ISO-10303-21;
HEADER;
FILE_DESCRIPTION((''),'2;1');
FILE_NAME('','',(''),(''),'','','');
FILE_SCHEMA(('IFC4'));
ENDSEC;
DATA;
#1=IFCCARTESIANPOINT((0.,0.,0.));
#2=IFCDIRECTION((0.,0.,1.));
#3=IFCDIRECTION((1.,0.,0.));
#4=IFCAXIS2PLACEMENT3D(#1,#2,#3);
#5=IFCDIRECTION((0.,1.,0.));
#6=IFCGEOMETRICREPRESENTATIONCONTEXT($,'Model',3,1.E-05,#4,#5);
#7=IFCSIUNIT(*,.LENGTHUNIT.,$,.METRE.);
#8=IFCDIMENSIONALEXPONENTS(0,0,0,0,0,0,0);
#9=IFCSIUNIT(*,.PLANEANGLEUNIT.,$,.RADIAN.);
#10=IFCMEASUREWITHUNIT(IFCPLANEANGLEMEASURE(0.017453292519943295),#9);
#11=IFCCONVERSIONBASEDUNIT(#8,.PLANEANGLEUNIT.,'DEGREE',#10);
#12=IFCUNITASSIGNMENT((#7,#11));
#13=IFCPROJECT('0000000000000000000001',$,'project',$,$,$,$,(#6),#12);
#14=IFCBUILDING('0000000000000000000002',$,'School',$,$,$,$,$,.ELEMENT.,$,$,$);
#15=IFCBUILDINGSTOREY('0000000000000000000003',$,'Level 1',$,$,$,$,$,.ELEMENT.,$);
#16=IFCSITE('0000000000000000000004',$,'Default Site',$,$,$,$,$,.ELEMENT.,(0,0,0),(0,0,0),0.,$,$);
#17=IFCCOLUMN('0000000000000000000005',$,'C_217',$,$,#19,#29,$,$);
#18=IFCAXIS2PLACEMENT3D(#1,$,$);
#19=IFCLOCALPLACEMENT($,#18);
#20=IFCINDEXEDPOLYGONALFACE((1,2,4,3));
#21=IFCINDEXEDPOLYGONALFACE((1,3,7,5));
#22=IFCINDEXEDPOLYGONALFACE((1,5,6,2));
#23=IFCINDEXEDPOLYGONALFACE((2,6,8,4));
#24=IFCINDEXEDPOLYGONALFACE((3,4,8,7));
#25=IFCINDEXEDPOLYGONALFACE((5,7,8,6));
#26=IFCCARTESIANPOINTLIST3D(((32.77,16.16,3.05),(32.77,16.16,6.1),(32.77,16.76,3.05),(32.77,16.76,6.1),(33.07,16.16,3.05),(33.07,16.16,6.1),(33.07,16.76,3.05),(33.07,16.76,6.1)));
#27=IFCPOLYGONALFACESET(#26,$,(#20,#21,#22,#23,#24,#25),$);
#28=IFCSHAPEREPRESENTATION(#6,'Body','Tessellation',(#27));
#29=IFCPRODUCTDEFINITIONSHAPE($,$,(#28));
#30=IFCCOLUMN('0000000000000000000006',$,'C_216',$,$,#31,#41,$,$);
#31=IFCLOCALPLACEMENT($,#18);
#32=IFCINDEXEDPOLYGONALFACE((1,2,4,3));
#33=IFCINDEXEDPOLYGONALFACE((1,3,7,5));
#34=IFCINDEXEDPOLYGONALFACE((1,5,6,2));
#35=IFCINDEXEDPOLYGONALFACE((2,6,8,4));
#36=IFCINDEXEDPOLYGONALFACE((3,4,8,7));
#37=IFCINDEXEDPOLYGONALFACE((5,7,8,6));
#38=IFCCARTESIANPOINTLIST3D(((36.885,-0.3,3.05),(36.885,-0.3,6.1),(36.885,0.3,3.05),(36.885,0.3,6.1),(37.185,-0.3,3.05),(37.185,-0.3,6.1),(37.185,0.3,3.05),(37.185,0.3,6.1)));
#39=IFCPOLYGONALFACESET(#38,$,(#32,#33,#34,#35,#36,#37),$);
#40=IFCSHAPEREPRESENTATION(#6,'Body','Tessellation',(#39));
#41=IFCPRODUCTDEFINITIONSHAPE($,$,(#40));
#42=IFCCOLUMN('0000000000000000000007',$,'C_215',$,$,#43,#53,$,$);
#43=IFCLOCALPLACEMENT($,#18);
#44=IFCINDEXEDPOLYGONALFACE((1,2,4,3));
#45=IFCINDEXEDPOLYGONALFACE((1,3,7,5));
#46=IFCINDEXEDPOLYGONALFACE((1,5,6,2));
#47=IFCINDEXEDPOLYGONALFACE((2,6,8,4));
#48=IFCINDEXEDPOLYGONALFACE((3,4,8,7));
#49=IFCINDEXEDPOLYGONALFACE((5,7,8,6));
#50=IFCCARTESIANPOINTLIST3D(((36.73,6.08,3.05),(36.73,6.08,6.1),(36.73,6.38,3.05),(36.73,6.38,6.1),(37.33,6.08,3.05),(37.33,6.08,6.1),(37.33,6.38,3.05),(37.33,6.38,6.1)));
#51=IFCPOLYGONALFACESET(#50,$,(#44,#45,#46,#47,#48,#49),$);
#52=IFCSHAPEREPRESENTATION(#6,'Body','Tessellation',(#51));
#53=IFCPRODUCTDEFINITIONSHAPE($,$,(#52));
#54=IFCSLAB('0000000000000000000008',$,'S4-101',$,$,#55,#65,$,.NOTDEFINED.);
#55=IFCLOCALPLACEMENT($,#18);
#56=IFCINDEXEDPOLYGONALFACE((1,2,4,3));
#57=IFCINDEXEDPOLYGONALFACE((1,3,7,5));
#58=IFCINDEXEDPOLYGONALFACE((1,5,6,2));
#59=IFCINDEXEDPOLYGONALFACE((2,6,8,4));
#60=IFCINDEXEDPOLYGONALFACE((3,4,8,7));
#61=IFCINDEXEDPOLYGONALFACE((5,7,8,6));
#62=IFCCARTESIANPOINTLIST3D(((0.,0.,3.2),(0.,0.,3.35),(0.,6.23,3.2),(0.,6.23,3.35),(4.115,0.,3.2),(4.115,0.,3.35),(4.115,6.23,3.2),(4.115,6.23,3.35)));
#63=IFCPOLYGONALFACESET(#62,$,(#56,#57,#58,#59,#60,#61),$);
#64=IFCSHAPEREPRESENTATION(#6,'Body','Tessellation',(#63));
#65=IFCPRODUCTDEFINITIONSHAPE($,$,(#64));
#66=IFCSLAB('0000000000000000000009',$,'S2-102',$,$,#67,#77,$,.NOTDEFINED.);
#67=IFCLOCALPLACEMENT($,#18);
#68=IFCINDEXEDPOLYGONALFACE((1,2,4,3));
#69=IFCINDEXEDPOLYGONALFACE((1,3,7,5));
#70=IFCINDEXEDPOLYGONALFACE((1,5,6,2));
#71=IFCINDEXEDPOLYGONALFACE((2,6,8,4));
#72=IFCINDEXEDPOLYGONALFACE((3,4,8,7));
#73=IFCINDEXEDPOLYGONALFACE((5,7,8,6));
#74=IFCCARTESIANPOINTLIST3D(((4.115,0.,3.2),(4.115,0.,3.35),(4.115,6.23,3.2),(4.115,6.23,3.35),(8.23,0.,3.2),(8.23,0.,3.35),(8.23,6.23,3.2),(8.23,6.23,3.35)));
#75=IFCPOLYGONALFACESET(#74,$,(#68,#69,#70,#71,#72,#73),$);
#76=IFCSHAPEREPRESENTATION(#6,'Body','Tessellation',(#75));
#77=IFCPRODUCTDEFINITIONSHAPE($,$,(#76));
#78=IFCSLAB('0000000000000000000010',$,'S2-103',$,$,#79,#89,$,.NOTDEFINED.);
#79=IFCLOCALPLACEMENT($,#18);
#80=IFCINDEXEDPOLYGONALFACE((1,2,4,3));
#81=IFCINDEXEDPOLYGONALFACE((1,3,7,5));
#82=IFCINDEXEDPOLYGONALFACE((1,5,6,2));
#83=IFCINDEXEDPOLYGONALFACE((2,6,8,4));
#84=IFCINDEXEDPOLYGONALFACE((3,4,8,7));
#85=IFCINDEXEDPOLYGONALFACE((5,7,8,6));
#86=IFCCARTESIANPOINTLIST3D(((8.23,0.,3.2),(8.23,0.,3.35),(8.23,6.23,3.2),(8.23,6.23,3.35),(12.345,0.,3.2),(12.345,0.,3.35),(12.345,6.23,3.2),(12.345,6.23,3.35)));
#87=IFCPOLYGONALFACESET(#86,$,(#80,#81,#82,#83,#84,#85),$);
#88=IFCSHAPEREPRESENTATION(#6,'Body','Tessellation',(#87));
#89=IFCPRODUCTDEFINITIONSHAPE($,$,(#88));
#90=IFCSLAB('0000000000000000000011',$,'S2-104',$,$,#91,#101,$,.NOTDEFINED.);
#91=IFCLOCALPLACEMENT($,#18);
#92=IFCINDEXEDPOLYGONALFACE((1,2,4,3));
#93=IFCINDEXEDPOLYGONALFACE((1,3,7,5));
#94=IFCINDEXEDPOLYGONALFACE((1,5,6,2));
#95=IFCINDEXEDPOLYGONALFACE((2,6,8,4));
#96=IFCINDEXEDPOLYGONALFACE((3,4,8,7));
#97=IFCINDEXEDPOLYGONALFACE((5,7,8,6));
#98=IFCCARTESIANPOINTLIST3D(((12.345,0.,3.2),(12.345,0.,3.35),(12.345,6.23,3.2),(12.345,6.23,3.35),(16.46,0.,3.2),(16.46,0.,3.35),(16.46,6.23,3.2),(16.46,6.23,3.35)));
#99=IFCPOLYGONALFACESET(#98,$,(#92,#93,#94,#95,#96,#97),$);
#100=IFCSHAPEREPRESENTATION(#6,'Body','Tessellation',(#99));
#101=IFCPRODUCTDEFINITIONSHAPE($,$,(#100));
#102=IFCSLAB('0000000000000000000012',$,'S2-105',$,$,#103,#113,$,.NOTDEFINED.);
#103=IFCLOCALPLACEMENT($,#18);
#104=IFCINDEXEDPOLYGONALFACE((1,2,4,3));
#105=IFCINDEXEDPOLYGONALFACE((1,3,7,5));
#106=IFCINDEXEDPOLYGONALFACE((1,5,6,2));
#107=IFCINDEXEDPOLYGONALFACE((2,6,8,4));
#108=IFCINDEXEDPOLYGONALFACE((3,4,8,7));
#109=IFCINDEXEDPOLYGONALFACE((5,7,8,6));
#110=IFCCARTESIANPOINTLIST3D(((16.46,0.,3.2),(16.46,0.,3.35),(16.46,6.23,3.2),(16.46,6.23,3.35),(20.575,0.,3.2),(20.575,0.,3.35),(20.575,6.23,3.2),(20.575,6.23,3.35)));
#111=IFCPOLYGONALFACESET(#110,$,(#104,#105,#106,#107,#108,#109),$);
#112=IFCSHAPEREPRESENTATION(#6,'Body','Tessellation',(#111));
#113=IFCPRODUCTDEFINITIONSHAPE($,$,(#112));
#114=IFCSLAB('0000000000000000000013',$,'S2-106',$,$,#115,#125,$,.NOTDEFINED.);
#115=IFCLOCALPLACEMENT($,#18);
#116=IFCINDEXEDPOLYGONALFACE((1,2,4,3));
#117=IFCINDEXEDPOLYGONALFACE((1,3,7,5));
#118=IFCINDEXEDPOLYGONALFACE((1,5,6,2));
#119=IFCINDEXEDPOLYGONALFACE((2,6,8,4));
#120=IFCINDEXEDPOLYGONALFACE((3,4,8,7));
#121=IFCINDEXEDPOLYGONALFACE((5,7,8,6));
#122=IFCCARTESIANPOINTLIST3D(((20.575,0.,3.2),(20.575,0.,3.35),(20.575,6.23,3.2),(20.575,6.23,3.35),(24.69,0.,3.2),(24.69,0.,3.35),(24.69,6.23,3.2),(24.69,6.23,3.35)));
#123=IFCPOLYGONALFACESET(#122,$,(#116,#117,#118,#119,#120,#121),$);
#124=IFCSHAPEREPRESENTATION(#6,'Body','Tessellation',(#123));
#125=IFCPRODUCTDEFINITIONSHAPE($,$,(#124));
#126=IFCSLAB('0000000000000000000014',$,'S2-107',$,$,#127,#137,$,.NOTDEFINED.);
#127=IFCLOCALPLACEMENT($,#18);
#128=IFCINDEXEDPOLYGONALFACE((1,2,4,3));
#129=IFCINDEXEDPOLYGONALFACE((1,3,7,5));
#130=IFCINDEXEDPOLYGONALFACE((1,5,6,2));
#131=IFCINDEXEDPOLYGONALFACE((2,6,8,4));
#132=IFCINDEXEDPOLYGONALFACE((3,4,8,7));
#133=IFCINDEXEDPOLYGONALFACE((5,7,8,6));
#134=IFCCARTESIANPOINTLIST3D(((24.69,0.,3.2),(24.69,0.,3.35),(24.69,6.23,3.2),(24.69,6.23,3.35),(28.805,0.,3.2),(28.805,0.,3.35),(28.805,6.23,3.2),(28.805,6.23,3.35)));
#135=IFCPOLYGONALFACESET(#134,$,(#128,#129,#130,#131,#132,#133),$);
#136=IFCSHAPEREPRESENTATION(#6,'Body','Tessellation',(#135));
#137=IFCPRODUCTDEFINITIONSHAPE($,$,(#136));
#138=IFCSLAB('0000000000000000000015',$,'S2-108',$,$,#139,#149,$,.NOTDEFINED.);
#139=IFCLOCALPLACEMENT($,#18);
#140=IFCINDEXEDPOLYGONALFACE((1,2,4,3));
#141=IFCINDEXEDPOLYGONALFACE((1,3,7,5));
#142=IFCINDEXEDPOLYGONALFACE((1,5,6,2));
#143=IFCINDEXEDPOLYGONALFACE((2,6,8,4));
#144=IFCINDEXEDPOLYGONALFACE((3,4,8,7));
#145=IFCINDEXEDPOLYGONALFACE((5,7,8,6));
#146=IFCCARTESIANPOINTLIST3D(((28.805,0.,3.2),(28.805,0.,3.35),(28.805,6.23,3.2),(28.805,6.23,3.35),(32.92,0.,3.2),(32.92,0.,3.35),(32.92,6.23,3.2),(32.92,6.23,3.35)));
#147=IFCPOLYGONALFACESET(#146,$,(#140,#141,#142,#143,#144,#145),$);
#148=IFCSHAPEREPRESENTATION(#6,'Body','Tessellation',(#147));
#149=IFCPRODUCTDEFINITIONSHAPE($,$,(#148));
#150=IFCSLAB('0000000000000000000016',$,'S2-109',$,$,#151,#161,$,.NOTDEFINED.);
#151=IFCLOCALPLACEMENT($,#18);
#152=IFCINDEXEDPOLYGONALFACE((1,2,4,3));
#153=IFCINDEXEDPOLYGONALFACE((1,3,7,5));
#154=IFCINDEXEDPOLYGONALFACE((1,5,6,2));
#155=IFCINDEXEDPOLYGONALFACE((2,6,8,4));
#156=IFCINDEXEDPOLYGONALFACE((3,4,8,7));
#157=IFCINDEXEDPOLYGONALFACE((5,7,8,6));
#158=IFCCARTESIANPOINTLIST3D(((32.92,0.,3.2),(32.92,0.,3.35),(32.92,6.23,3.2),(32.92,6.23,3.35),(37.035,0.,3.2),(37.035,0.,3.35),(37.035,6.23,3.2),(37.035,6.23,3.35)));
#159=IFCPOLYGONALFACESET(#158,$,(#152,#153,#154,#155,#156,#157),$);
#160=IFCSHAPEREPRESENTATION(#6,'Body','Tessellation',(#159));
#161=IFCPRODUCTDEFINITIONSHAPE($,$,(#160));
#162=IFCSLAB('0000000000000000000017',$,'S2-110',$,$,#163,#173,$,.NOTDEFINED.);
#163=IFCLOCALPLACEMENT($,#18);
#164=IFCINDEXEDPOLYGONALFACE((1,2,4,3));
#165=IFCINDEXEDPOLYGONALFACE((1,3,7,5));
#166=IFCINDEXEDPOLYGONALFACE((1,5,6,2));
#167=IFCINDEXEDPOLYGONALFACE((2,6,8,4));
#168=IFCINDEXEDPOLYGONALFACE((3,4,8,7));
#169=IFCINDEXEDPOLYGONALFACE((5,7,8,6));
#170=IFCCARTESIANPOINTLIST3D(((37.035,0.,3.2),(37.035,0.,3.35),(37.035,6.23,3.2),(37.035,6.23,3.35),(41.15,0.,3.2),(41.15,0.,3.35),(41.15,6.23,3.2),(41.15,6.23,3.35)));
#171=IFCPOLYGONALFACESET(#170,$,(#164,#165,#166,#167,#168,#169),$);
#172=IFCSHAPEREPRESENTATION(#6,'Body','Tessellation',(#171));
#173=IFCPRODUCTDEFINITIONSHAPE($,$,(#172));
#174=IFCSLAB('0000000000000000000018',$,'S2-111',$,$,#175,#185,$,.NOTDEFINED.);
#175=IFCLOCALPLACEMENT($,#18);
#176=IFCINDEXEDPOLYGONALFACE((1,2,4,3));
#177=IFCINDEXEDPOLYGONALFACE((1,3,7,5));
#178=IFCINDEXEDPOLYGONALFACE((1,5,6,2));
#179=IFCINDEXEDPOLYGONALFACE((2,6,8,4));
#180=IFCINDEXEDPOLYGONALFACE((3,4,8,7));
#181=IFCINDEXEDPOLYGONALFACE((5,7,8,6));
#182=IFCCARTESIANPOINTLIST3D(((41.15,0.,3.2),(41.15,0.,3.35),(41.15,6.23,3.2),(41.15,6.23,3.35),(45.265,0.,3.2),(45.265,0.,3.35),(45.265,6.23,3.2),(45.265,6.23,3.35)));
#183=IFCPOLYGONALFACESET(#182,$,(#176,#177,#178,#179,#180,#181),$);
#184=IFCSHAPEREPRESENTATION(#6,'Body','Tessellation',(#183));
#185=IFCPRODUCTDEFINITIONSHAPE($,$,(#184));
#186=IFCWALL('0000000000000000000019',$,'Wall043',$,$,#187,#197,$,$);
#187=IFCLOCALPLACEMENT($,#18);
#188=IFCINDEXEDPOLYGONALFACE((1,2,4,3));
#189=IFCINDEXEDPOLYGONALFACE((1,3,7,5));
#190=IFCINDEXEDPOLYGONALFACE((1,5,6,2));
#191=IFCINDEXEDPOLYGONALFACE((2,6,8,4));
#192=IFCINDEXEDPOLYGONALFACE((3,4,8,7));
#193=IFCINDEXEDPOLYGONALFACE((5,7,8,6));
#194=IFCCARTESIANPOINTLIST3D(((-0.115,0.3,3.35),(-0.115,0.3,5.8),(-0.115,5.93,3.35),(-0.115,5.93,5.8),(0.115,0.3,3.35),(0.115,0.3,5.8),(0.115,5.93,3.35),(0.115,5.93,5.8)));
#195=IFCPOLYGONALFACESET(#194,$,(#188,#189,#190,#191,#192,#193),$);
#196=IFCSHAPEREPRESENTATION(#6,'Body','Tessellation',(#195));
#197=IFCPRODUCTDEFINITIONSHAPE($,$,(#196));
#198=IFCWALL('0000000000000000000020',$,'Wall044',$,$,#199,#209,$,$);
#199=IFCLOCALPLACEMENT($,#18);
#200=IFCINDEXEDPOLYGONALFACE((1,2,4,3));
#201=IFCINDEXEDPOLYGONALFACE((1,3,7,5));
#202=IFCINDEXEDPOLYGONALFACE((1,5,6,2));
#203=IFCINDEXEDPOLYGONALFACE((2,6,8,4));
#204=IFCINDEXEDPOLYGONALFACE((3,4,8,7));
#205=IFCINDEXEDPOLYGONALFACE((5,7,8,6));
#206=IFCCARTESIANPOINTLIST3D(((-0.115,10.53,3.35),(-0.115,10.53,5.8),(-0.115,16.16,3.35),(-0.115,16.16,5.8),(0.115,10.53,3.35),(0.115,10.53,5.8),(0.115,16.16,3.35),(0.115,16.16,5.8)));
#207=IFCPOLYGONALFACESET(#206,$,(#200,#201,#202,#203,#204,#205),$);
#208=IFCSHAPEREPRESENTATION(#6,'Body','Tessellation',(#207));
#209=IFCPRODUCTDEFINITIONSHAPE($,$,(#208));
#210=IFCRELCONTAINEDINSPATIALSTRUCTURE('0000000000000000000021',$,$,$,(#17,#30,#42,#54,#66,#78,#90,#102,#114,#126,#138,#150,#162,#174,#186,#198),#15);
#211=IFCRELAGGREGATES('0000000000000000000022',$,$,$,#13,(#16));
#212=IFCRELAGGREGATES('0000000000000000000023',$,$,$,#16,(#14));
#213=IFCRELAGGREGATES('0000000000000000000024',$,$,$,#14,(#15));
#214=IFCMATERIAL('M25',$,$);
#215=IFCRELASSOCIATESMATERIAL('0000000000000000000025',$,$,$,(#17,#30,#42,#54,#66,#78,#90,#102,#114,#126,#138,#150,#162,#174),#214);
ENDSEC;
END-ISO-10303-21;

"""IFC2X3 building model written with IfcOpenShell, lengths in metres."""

from ifc_helpers import new_model, entity, si_unit, converted_unit, direction, frame, frame_2d, origin_with_axes, place, context, project, spatial, rectangle, extrude, material, element, save


model = new_model("IFC2X3")

# Units and contexts
model_context = context("Model", 3, precision=1e-05, world=origin_with_axes(), true_north=direction((0.0, 1.0, 0.0)))
ifc_project = project(units=[si_unit("LENGTHUNIT", "METRE"), converted_unit("PLANEANGLEUNIT", "DEGREE", entity("IfcPlaneAngleMeasure", 0.017453292519943295), si_unit("PLANEANGLEUNIT", "RADIAN"), dimensions=[0, 0, 0, 0, 0, 0, 0])], contexts=[model_context])

# Site, building, storey
site = spatial("IfcSite", under=ifc_project, Name="Default Site", CompositionType="ELEMENT", RefLatitude=(0, 0, 0), RefLongitude=(0, 0, 0), RefElevation=0.0)
building = spatial("IfcBuilding", under=site, Name="School", CompositionType="ELEMENT")
storey = spatial("IfcBuildingStorey", under=building, Name="Level 1", CompositionType="ELEMENT")

# Columns
ifc_material = material(Name="M25")
placement = place(None, origin_with_axes())
element("IfcColumn", 1, at=placement, inside=storey, material=ifc_material, Name="C_217", context=model_context, shape_type="SweptSolid", body=[
    extrude(rectangle(XDim=0.3, YDim=0.6, at=frame_2d((0.0, 0.0), x_axis=(1.0, 0.0, 0.0))), frame((32.92, 16.46, 3.05), z_axis=(0.0, 0.0, 1.0), x_axis=(1.0, 0.0, 0.0)), (0.0, 0.0, 1.0), 3.05),
])
element("IfcColumn", 2, at=placement, inside=storey, material=ifc_material, Name="C_216", context=model_context, shape_type="SweptSolid", body=[
    extrude(rectangle(XDim=0.3, YDim=0.6, at=frame_2d((0.0, 0.0), x_axis=(1.0, 0.0, 0.0))), frame((37.035, 0.0, 3.05), z_axis=(0.0, 0.0, 1.0), x_axis=(1.0, 0.0, 0.0)), (0.0, 0.0, 1.0), 3.05),
])
element("IfcColumn", 3, at=placement, inside=storey, material=ifc_material, Name="C_215", context=model_context, shape_type="SweptSolid", body=[
    extrude(rectangle(XDim=0.6, YDim=0.3, at=frame_2d((0.0, 0.0), x_axis=(1.0, 0.0, 0.0))), frame((37.03, 6.23, 3.05), z_axis=(0.0, 0.0, 1.0), x_axis=(1.0, 0.0, 0.0)), (0.0, 0.0, 1.0), 3.05),
])

# Slabs
element("IfcSlab", 4, at=placement, inside=storey, material=ifc_material, Name="S4-101", PredefinedType="NOTDEFINED", context=model_context, shape_type="SweptSolid", body=[
    extrude(rectangle(XDim=4.115, YDim=6.23, at=frame_2d((0.0, 0.0), x_axis=(1.0, 0.0, 0.0))), frame((2.0575, 3.115, 3.2), z_axis=(0.0, 0.0, 1.0), x_axis=(1.0, 0.0, 0.0)), (0.0, 0.0, 1.0), 0.15),
])
element("IfcSlab", 5, at=placement, inside=storey, material=ifc_material, Name="S2-102", PredefinedType="NOTDEFINED", context=model_context, shape_type="SweptSolid", body=[
    extrude(rectangle(XDim=4.115, YDim=6.23, at=frame_2d((0.0, 0.0), x_axis=(1.0, 0.0, 0.0))), frame((6.1725, 3.115, 3.2), z_axis=(0.0, 0.0, 1.0), x_axis=(1.0, 0.0, 0.0)), (0.0, 0.0, 1.0), 0.15),
])
element("IfcSlab", 6, at=placement, inside=storey, material=ifc_material, Name="S2-103", PredefinedType="NOTDEFINED", context=model_context, shape_type="SweptSolid", body=[
    extrude(rectangle(XDim=4.115, YDim=6.23, at=frame_2d((0.0, 0.0), x_axis=(1.0, 0.0, 0.0))), frame((10.2875, 3.115, 3.2), z_axis=(0.0, 0.0, 1.0), x_axis=(1.0, 0.0, 0.0)), (0.0, 0.0, 1.0), 0.15),
])
element("IfcSlab", 7, at=placement, inside=storey, material=ifc_material, Name="S2-104", PredefinedType="NOTDEFINED", context=model_context, shape_type="SweptSolid", body=[
    extrude(rectangle(XDim=4.115, YDim=6.23, at=frame_2d((0.0, 0.0), x_axis=(1.0, 0.0, 0.0))), frame((14.4025, 3.115, 3.2), z_axis=(0.0, 0.0, 1.0), x_axis=(1.0, 0.0, 0.0)), (0.0, 0.0, 1.0), 0.15),
])
element("IfcSlab", 8, at=placement, inside=storey, material=ifc_material, Name="S2-105", PredefinedType="NOTDEFINED", context=model_context, shape_type="SweptSolid", body=[
    extrude(rectangle(XDim=4.115, YDim=6.23, at=frame_2d((0.0, 0.0), x_axis=(1.0, 0.0, 0.0))), frame((18.5175, 3.115, 3.2), z_axis=(0.0, 0.0, 1.0), x_axis=(1.0, 0.0, 0.0)), (0.0, 0.0, 1.0), 0.15),
])
element("IfcSlab", 9, at=placement, inside=storey, material=ifc_material, Name="S2-106", PredefinedType="NOTDEFINED", context=model_context, shape_type="SweptSolid", body=[
    extrude(rectangle(XDim=4.115, YDim=6.23, at=frame_2d((0.0, 0.0), x_axis=(1.0, 0.0, 0.0))), frame((22.6325, 3.115, 3.2), z_axis=(0.0, 0.0, 1.0), x_axis=(1.0, 0.0, 0.0)), (0.0, 0.0, 1.0), 0.15),
])
element("IfcSlab", 10, at=placement, inside=storey, material=ifc_material, Name="S2-107", PredefinedType="NOTDEFINED", context=model_context, shape_type="SweptSolid", body=[
    extrude(rectangle(XDim=4.115, YDim=6.23, at=frame_2d((0.0, 0.0), x_axis=(1.0, 0.0, 0.0))), frame((26.7475, 3.115, 3.2), z_axis=(0.0, 0.0, 1.0), x_axis=(1.0, 0.0, 0.0)), (0.0, 0.0, 1.0), 0.15),
])
element("IfcSlab", 11, at=placement, inside=storey, material=ifc_material, Name="S2-108", PredefinedType="NOTDEFINED", context=model_context, shape_type="SweptSolid", body=[
    extrude(rectangle(XDim=4.115, YDim=6.23, at=frame_2d((0.0, 0.0), x_axis=(1.0, 0.0, 0.0))), frame((30.8625, 3.115, 3.2), z_axis=(0.0, 0.0, 1.0), x_axis=(1.0, 0.0, 0.0)), (0.0, 0.0, 1.0), 0.15),
])
element("IfcSlab", 12, at=placement, inside=storey, material=ifc_material, Name="S2-109", PredefinedType="NOTDEFINED", context=model_context, shape_type="SweptSolid", body=[
    extrude(rectangle(XDim=4.115, YDim=6.23, at=frame_2d((0.0, 0.0), x_axis=(1.0, 0.0, 0.0))), frame((34.9775, 3.115, 3.2), z_axis=(0.0, 0.0, 1.0), x_axis=(1.0, 0.0, 0.0)), (0.0, 0.0, 1.0), 0.15),
])
element("IfcSlab", 13, at=placement, inside=storey, material=ifc_material, Name="S2-110", PredefinedType="NOTDEFINED", context=model_context, shape_type="SweptSolid", body=[
    extrude(rectangle(XDim=4.115, YDim=6.23, at=frame_2d((0.0, 0.0), x_axis=(1.0, 0.0, 0.0))), frame((39.0925, 3.115, 3.2), z_axis=(0.0, 0.0, 1.0), x_axis=(1.0, 0.0, 0.0)), (0.0, 0.0, 1.0), 0.15),
])
element("IfcSlab", 14, at=placement, inside=storey, material=ifc_material, Name="S2-111", PredefinedType="NOTDEFINED", context=model_context, shape_type="SweptSolid", body=[
    extrude(rectangle(XDim=4.115, YDim=6.23, at=frame_2d((0.0, 0.0), x_axis=(1.0, 0.0, 0.0))), frame((43.2075, 3.115, 3.2), z_axis=(0.0, 0.0, 1.0), x_axis=(1.0, 0.0, 0.0)), (0.0, 0.0, 1.0), 0.15),
])

# Walls
element("IfcWall", 15, at=placement, inside=storey, Name="Wall043", context=model_context, shape_type="SweptSolid", body=[
    extrude(rectangle(XDim=5.63, YDim=0.23, at=frame_2d((0.0, 0.0), x_axis=(0.0, 1.0, 0.0))), frame((0.0, 3.115, 3.35), z_axis=(0.0, 0.0, 1.0), x_axis=(1.0, 0.0, 0.0)), (0.0, 0.0, 1.0), 2.45),
])
element("IfcWall", 16, at=placement, inside=storey, Name="Wall044", context=model_context, shape_type="SweptSolid", body=[
    extrude(rectangle(XDim=5.63, YDim=0.23, at=frame_2d((0.0, 0.0), x_axis=(0.0, 1.0, 0.0))), frame((0.0, 13.345, 3.35), z_axis=(0.0, 0.0, 1.0), x_axis=(1.0, 0.0, 0.0)), (0.0, 0.0, 1.0), 2.45),
])

save(model, "model.ifc")
